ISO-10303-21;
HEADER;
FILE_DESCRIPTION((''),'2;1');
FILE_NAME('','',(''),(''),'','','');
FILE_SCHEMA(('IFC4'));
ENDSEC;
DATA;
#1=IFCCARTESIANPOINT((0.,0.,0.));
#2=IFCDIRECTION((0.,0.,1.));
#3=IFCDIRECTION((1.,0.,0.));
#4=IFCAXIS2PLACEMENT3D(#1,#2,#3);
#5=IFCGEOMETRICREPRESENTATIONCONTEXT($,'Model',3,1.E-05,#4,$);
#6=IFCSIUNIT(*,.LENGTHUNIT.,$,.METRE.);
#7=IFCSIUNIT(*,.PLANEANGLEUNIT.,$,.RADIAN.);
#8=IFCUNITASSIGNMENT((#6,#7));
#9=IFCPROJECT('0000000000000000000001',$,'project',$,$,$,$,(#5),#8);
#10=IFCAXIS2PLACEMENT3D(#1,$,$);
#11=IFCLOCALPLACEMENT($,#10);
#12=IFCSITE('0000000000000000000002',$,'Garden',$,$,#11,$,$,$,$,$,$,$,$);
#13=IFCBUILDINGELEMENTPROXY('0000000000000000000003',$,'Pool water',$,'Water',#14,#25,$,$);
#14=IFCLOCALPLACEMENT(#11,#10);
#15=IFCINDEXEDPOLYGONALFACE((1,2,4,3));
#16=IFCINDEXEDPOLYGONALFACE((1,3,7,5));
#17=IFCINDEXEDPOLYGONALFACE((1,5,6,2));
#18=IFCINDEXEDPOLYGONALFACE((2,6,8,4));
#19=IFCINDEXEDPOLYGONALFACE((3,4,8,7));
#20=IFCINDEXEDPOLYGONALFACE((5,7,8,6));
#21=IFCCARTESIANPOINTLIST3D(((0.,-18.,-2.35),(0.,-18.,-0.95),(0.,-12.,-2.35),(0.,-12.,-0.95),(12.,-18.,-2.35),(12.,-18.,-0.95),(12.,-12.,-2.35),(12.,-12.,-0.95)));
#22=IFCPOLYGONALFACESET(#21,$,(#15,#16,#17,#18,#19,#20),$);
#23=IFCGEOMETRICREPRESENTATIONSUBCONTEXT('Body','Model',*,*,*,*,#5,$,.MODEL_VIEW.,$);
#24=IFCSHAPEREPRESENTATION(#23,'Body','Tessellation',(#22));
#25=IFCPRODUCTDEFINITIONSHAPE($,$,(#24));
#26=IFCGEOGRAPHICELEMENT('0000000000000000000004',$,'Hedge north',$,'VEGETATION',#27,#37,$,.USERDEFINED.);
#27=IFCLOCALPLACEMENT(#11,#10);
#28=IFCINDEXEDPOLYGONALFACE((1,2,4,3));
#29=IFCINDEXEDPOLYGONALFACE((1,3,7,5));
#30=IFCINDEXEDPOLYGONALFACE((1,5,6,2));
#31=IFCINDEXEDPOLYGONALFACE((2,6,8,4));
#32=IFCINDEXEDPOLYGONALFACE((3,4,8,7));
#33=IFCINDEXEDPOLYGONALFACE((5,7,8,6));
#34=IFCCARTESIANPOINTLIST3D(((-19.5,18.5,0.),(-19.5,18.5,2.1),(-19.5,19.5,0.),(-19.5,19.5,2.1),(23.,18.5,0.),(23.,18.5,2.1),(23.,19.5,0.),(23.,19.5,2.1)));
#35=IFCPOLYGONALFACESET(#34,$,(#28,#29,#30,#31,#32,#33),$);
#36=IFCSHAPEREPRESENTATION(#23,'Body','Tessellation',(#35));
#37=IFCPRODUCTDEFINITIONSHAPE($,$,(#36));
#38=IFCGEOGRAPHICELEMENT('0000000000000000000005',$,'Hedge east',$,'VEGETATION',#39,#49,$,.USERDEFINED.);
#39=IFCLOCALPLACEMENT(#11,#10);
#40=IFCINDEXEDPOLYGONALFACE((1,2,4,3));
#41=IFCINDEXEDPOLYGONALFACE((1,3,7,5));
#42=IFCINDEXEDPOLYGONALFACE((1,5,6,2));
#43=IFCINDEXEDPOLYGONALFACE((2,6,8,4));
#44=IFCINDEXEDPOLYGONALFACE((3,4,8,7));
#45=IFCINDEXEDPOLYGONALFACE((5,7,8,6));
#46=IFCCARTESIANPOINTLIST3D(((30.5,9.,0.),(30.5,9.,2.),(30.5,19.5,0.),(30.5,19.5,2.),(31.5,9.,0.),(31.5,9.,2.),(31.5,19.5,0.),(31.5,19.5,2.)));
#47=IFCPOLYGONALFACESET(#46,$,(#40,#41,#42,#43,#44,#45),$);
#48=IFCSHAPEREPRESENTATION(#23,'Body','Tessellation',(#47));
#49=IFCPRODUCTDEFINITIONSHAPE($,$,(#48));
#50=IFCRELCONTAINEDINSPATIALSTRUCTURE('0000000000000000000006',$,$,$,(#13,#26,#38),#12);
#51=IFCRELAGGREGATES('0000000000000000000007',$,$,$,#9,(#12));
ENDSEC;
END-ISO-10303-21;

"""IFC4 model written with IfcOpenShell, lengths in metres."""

from ifc_helpers import new_model, si_unit, frame, frame_2d, origin, origin_with_axes, place, context, subcontext, project, spatial, rectangle, extrude, element, save


model = new_model("IFC4")

# Units and contexts
model_context = context("Model", 3, precision=1e-05, world=origin_with_axes())
body_context = subcontext(model_context, "Body", "Model", "MODEL_VIEW")
ifc_project = project(units=[si_unit("LENGTHUNIT", "METRE"), si_unit("PLANEANGLEUNIT", "RADIAN")], contexts=[model_context])

# Site
site_placement = place(None, origin())
site = spatial("IfcSite", under=ifc_project, at=site_placement, Name="Garden")

# Building element proxy
proxy_1_placement = place(site_placement, origin())
element("IfcBuildingElementProxy", 1, at=proxy_1_placement, inside=site, Name="Pool water", ObjectType="Water", context=body_context, shape_type="SweptSolid", body=[
    extrude(rectangle(XDim=12.0, YDim=6.0, at=frame_2d((6.0, 3.0))), frame((0.0, -18.0, -2.35)), (0.0, 0.0, 1.0), 1.4),
])

# Geographic elements
geographic_element_1_placement = place(site_placement, origin())
element("IfcGeographicElement", 2, at=geographic_element_1_placement, inside=site, Name="Hedge north", ObjectType="VEGETATION", PredefinedType="USERDEFINED", context=body_context, shape_type="SweptSolid", body=[
    extrude(rectangle(XDim=42.5, YDim=1.0, at=frame_2d((21.25, 0.5))), frame((-19.5, 18.5, 0.0)), (0.0, 0.0, 1.0), 2.1),
])
geographic_element_2_placement = place(site_placement, origin())
element("IfcGeographicElement", 3, at=geographic_element_2_placement, inside=site, Name="Hedge east", ObjectType="VEGETATION", PredefinedType="USERDEFINED", context=body_context, shape_type="SweptSolid", body=[
    extrude(rectangle(XDim=1.0, YDim=10.5, at=frame_2d((0.5, 5.25))), frame((30.5, 9.0, 0.0)), (0.0, 0.0, 1.0), 2.0),
])

save(model, "model.ifc")
